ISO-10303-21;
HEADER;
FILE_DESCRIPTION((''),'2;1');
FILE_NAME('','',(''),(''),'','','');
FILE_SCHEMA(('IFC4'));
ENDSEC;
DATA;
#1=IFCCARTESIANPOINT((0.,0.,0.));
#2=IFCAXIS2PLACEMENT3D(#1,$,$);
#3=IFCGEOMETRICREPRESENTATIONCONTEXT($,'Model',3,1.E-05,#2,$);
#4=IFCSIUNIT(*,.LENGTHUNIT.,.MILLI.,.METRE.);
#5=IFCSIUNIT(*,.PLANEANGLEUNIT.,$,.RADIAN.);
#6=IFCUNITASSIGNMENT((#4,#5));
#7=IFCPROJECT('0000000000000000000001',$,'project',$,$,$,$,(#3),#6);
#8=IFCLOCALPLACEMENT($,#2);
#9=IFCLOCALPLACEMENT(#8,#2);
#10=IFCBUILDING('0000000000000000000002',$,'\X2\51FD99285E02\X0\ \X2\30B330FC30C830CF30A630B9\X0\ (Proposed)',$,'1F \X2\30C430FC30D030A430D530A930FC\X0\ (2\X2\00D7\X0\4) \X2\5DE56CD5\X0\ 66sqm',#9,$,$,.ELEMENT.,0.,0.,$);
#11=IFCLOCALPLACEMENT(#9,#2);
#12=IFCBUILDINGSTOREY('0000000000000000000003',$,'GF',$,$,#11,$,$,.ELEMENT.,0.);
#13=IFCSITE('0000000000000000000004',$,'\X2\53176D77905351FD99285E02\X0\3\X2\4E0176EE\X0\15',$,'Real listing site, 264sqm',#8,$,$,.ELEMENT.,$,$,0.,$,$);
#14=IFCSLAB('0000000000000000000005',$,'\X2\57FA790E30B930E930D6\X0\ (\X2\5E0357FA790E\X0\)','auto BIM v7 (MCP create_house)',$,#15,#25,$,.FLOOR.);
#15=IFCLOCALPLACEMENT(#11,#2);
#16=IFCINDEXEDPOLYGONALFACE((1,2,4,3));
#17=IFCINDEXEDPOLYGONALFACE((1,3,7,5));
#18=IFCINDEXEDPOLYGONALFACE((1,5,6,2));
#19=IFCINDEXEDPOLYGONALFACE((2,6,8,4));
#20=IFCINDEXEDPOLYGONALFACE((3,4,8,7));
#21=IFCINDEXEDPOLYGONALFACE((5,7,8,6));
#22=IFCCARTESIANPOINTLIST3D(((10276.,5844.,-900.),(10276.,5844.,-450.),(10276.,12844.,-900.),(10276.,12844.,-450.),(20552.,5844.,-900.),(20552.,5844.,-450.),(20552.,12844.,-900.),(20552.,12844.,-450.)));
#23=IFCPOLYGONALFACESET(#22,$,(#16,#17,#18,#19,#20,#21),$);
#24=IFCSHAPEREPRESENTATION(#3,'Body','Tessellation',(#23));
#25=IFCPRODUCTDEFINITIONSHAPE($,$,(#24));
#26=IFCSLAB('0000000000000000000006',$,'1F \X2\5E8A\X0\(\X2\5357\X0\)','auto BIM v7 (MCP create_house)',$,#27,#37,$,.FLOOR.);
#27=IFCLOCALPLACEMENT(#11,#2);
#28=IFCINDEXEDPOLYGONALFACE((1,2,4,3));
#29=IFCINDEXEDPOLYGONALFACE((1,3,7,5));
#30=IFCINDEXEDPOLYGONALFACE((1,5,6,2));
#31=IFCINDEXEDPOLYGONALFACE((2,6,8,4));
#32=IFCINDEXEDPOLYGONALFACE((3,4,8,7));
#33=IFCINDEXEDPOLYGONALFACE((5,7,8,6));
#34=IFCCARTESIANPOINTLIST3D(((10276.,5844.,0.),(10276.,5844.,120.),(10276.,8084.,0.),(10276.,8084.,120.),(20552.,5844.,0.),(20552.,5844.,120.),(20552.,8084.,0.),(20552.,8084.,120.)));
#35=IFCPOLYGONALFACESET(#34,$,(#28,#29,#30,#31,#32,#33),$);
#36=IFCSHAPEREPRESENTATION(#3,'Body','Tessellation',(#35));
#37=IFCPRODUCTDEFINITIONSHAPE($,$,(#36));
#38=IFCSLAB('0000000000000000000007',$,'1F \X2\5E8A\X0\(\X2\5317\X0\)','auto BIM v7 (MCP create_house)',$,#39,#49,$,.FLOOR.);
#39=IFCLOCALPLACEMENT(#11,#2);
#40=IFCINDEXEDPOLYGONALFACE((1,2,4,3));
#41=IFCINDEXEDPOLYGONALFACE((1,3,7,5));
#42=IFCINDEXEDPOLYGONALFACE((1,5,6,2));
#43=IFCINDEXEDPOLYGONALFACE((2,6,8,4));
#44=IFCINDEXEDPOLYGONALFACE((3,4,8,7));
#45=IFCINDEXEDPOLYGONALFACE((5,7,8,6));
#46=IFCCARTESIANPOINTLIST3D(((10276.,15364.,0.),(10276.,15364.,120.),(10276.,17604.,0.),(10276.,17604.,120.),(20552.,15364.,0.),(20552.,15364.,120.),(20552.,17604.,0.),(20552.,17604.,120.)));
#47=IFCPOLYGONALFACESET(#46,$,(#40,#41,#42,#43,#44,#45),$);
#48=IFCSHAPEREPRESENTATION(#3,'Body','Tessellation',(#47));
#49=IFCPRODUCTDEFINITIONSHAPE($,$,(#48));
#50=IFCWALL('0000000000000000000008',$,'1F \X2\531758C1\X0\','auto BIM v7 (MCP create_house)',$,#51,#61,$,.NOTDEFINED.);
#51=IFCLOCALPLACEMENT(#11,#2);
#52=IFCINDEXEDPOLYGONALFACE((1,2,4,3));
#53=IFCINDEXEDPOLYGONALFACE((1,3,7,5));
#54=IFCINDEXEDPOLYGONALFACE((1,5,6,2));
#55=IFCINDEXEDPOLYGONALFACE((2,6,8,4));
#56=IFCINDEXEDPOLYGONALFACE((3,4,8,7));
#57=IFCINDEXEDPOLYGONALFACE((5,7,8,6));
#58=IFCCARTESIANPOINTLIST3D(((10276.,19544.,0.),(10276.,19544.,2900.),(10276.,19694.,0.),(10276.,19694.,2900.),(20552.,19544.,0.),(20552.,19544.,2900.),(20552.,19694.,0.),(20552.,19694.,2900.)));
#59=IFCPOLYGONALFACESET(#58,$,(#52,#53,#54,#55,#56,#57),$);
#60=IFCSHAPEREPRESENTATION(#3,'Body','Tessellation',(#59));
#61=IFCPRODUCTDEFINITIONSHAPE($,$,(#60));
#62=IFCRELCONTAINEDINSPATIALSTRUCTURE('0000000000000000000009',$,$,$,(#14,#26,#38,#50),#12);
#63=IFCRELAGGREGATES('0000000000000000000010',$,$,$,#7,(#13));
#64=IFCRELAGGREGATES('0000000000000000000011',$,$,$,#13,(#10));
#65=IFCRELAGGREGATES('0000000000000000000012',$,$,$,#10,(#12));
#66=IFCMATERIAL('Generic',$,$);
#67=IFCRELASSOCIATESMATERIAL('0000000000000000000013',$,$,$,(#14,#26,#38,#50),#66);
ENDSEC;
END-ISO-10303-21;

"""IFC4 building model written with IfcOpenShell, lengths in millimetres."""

from ifc_helpers import new_model, si_unit, frame, frame_2d, origin, place, context, project, spatial, rectangle, extrude, material, element, save


model = new_model("IFC4")

# Units and contexts
model_context = context("Model", 3, precision=1e-05, world=origin())
ifc_project = project(units=[si_unit("LENGTHUNIT", "METRE", prefix="MILLI"), si_unit("PLANEANGLEUNIT", "RADIAN")], contexts=[model_context])

# Site, building, storey
site_placement = place(None, origin())
site = spatial("IfcSite", under=ifc_project, at=site_placement, Name="北海道函館市3丁目15", ObjectType="Real listing site, 264sqm", CompositionType="ELEMENT", RefElevation=0.0)
building_placement = place(site_placement, origin())
building = spatial("IfcBuilding", under=site, at=building_placement, Name="函館市 コートハウス (Proposed)", ObjectType="1F ツーバイフォー (2×4) 工法 66sqm", CompositionType="ELEMENT", ElevationOfRefHeight=0.0, ElevationOfTerrain=0.0)
storey_placement = place(building_placement, origin())
storey = spatial("IfcBuildingStorey", under=building, at=storey_placement, Name="GF", CompositionType="ELEMENT", Elevation=0.0)

# Slabs
ifc_material = material(Name="Generic")
slab_1_placement = place(storey_placement, frame((5138.0, 2922.0, -450.0)))
element("IfcSlab", 1, at=slab_1_placement, inside=storey, material=ifc_material, Name="基礎スラブ (布基礎)", Description="auto BIM v7 (MCP create_house)", PredefinedType="FLOOR", context=model_context, shape_type="SweptSolid", body=[
    extrude(rectangle(XDim=10276.0, YDim=7000.0, at=frame_2d((5138.0, 3500.0))), frame((5138.0, 2922.0, -450.0)), (0.0, 0.0, 1.0), 450.0),
])
slab_2_placement = place(storey_placement, frame((5138.0, 2922.0, 0.0)))
element("IfcSlab", 2, at=slab_2_placement, inside=storey, material=ifc_material, Name="1F 床(南)", Description="auto BIM v7 (MCP create_house)", PredefinedType="FLOOR", context=model_context, shape_type="SweptSolid", body=[
    extrude(rectangle(XDim=10276.0, YDim=2240.0, at=frame_2d((5138.0, 1120.0))), frame((5138.0, 2922.0, 0.0)), (0.0, 0.0, 1.0), 120.0),
])
slab_3_placement = place(storey_placement, frame((5138.0, 7682.0, 0.0)))
element("IfcSlab", 3, at=slab_3_placement, inside=storey, material=ifc_material, Name="1F 床(北)", Description="auto BIM v7 (MCP create_house)", PredefinedType="FLOOR", context=model_context, shape_type="SweptSolid", body=[
    extrude(rectangle(XDim=10276.0, YDim=2240.0, at=frame_2d((5138.0, 1120.0))), frame((5138.0, 7682.0, 0.0)), (0.0, 0.0, 1.0), 120.0),
])

# Wall
wall_1_placement = place(storey_placement, frame((5138.0, 9772.0, 0.0)))
element("IfcWall", 4, at=wall_1_placement, inside=storey, material=ifc_material, Name="1F 北壁", Description="auto BIM v7 (MCP create_house)", PredefinedType="NOTDEFINED", context=model_context, shape_type="SweptSolid", body=[
    extrude(rectangle(XDim=10276.0, YDim=150.0, at=frame_2d((5138.0, 75.0))), frame((5138.0, 9772.0, 0.0)), (0.0, 0.0, 1.0), 2900.0),
])

save(model, "model.ifc")
